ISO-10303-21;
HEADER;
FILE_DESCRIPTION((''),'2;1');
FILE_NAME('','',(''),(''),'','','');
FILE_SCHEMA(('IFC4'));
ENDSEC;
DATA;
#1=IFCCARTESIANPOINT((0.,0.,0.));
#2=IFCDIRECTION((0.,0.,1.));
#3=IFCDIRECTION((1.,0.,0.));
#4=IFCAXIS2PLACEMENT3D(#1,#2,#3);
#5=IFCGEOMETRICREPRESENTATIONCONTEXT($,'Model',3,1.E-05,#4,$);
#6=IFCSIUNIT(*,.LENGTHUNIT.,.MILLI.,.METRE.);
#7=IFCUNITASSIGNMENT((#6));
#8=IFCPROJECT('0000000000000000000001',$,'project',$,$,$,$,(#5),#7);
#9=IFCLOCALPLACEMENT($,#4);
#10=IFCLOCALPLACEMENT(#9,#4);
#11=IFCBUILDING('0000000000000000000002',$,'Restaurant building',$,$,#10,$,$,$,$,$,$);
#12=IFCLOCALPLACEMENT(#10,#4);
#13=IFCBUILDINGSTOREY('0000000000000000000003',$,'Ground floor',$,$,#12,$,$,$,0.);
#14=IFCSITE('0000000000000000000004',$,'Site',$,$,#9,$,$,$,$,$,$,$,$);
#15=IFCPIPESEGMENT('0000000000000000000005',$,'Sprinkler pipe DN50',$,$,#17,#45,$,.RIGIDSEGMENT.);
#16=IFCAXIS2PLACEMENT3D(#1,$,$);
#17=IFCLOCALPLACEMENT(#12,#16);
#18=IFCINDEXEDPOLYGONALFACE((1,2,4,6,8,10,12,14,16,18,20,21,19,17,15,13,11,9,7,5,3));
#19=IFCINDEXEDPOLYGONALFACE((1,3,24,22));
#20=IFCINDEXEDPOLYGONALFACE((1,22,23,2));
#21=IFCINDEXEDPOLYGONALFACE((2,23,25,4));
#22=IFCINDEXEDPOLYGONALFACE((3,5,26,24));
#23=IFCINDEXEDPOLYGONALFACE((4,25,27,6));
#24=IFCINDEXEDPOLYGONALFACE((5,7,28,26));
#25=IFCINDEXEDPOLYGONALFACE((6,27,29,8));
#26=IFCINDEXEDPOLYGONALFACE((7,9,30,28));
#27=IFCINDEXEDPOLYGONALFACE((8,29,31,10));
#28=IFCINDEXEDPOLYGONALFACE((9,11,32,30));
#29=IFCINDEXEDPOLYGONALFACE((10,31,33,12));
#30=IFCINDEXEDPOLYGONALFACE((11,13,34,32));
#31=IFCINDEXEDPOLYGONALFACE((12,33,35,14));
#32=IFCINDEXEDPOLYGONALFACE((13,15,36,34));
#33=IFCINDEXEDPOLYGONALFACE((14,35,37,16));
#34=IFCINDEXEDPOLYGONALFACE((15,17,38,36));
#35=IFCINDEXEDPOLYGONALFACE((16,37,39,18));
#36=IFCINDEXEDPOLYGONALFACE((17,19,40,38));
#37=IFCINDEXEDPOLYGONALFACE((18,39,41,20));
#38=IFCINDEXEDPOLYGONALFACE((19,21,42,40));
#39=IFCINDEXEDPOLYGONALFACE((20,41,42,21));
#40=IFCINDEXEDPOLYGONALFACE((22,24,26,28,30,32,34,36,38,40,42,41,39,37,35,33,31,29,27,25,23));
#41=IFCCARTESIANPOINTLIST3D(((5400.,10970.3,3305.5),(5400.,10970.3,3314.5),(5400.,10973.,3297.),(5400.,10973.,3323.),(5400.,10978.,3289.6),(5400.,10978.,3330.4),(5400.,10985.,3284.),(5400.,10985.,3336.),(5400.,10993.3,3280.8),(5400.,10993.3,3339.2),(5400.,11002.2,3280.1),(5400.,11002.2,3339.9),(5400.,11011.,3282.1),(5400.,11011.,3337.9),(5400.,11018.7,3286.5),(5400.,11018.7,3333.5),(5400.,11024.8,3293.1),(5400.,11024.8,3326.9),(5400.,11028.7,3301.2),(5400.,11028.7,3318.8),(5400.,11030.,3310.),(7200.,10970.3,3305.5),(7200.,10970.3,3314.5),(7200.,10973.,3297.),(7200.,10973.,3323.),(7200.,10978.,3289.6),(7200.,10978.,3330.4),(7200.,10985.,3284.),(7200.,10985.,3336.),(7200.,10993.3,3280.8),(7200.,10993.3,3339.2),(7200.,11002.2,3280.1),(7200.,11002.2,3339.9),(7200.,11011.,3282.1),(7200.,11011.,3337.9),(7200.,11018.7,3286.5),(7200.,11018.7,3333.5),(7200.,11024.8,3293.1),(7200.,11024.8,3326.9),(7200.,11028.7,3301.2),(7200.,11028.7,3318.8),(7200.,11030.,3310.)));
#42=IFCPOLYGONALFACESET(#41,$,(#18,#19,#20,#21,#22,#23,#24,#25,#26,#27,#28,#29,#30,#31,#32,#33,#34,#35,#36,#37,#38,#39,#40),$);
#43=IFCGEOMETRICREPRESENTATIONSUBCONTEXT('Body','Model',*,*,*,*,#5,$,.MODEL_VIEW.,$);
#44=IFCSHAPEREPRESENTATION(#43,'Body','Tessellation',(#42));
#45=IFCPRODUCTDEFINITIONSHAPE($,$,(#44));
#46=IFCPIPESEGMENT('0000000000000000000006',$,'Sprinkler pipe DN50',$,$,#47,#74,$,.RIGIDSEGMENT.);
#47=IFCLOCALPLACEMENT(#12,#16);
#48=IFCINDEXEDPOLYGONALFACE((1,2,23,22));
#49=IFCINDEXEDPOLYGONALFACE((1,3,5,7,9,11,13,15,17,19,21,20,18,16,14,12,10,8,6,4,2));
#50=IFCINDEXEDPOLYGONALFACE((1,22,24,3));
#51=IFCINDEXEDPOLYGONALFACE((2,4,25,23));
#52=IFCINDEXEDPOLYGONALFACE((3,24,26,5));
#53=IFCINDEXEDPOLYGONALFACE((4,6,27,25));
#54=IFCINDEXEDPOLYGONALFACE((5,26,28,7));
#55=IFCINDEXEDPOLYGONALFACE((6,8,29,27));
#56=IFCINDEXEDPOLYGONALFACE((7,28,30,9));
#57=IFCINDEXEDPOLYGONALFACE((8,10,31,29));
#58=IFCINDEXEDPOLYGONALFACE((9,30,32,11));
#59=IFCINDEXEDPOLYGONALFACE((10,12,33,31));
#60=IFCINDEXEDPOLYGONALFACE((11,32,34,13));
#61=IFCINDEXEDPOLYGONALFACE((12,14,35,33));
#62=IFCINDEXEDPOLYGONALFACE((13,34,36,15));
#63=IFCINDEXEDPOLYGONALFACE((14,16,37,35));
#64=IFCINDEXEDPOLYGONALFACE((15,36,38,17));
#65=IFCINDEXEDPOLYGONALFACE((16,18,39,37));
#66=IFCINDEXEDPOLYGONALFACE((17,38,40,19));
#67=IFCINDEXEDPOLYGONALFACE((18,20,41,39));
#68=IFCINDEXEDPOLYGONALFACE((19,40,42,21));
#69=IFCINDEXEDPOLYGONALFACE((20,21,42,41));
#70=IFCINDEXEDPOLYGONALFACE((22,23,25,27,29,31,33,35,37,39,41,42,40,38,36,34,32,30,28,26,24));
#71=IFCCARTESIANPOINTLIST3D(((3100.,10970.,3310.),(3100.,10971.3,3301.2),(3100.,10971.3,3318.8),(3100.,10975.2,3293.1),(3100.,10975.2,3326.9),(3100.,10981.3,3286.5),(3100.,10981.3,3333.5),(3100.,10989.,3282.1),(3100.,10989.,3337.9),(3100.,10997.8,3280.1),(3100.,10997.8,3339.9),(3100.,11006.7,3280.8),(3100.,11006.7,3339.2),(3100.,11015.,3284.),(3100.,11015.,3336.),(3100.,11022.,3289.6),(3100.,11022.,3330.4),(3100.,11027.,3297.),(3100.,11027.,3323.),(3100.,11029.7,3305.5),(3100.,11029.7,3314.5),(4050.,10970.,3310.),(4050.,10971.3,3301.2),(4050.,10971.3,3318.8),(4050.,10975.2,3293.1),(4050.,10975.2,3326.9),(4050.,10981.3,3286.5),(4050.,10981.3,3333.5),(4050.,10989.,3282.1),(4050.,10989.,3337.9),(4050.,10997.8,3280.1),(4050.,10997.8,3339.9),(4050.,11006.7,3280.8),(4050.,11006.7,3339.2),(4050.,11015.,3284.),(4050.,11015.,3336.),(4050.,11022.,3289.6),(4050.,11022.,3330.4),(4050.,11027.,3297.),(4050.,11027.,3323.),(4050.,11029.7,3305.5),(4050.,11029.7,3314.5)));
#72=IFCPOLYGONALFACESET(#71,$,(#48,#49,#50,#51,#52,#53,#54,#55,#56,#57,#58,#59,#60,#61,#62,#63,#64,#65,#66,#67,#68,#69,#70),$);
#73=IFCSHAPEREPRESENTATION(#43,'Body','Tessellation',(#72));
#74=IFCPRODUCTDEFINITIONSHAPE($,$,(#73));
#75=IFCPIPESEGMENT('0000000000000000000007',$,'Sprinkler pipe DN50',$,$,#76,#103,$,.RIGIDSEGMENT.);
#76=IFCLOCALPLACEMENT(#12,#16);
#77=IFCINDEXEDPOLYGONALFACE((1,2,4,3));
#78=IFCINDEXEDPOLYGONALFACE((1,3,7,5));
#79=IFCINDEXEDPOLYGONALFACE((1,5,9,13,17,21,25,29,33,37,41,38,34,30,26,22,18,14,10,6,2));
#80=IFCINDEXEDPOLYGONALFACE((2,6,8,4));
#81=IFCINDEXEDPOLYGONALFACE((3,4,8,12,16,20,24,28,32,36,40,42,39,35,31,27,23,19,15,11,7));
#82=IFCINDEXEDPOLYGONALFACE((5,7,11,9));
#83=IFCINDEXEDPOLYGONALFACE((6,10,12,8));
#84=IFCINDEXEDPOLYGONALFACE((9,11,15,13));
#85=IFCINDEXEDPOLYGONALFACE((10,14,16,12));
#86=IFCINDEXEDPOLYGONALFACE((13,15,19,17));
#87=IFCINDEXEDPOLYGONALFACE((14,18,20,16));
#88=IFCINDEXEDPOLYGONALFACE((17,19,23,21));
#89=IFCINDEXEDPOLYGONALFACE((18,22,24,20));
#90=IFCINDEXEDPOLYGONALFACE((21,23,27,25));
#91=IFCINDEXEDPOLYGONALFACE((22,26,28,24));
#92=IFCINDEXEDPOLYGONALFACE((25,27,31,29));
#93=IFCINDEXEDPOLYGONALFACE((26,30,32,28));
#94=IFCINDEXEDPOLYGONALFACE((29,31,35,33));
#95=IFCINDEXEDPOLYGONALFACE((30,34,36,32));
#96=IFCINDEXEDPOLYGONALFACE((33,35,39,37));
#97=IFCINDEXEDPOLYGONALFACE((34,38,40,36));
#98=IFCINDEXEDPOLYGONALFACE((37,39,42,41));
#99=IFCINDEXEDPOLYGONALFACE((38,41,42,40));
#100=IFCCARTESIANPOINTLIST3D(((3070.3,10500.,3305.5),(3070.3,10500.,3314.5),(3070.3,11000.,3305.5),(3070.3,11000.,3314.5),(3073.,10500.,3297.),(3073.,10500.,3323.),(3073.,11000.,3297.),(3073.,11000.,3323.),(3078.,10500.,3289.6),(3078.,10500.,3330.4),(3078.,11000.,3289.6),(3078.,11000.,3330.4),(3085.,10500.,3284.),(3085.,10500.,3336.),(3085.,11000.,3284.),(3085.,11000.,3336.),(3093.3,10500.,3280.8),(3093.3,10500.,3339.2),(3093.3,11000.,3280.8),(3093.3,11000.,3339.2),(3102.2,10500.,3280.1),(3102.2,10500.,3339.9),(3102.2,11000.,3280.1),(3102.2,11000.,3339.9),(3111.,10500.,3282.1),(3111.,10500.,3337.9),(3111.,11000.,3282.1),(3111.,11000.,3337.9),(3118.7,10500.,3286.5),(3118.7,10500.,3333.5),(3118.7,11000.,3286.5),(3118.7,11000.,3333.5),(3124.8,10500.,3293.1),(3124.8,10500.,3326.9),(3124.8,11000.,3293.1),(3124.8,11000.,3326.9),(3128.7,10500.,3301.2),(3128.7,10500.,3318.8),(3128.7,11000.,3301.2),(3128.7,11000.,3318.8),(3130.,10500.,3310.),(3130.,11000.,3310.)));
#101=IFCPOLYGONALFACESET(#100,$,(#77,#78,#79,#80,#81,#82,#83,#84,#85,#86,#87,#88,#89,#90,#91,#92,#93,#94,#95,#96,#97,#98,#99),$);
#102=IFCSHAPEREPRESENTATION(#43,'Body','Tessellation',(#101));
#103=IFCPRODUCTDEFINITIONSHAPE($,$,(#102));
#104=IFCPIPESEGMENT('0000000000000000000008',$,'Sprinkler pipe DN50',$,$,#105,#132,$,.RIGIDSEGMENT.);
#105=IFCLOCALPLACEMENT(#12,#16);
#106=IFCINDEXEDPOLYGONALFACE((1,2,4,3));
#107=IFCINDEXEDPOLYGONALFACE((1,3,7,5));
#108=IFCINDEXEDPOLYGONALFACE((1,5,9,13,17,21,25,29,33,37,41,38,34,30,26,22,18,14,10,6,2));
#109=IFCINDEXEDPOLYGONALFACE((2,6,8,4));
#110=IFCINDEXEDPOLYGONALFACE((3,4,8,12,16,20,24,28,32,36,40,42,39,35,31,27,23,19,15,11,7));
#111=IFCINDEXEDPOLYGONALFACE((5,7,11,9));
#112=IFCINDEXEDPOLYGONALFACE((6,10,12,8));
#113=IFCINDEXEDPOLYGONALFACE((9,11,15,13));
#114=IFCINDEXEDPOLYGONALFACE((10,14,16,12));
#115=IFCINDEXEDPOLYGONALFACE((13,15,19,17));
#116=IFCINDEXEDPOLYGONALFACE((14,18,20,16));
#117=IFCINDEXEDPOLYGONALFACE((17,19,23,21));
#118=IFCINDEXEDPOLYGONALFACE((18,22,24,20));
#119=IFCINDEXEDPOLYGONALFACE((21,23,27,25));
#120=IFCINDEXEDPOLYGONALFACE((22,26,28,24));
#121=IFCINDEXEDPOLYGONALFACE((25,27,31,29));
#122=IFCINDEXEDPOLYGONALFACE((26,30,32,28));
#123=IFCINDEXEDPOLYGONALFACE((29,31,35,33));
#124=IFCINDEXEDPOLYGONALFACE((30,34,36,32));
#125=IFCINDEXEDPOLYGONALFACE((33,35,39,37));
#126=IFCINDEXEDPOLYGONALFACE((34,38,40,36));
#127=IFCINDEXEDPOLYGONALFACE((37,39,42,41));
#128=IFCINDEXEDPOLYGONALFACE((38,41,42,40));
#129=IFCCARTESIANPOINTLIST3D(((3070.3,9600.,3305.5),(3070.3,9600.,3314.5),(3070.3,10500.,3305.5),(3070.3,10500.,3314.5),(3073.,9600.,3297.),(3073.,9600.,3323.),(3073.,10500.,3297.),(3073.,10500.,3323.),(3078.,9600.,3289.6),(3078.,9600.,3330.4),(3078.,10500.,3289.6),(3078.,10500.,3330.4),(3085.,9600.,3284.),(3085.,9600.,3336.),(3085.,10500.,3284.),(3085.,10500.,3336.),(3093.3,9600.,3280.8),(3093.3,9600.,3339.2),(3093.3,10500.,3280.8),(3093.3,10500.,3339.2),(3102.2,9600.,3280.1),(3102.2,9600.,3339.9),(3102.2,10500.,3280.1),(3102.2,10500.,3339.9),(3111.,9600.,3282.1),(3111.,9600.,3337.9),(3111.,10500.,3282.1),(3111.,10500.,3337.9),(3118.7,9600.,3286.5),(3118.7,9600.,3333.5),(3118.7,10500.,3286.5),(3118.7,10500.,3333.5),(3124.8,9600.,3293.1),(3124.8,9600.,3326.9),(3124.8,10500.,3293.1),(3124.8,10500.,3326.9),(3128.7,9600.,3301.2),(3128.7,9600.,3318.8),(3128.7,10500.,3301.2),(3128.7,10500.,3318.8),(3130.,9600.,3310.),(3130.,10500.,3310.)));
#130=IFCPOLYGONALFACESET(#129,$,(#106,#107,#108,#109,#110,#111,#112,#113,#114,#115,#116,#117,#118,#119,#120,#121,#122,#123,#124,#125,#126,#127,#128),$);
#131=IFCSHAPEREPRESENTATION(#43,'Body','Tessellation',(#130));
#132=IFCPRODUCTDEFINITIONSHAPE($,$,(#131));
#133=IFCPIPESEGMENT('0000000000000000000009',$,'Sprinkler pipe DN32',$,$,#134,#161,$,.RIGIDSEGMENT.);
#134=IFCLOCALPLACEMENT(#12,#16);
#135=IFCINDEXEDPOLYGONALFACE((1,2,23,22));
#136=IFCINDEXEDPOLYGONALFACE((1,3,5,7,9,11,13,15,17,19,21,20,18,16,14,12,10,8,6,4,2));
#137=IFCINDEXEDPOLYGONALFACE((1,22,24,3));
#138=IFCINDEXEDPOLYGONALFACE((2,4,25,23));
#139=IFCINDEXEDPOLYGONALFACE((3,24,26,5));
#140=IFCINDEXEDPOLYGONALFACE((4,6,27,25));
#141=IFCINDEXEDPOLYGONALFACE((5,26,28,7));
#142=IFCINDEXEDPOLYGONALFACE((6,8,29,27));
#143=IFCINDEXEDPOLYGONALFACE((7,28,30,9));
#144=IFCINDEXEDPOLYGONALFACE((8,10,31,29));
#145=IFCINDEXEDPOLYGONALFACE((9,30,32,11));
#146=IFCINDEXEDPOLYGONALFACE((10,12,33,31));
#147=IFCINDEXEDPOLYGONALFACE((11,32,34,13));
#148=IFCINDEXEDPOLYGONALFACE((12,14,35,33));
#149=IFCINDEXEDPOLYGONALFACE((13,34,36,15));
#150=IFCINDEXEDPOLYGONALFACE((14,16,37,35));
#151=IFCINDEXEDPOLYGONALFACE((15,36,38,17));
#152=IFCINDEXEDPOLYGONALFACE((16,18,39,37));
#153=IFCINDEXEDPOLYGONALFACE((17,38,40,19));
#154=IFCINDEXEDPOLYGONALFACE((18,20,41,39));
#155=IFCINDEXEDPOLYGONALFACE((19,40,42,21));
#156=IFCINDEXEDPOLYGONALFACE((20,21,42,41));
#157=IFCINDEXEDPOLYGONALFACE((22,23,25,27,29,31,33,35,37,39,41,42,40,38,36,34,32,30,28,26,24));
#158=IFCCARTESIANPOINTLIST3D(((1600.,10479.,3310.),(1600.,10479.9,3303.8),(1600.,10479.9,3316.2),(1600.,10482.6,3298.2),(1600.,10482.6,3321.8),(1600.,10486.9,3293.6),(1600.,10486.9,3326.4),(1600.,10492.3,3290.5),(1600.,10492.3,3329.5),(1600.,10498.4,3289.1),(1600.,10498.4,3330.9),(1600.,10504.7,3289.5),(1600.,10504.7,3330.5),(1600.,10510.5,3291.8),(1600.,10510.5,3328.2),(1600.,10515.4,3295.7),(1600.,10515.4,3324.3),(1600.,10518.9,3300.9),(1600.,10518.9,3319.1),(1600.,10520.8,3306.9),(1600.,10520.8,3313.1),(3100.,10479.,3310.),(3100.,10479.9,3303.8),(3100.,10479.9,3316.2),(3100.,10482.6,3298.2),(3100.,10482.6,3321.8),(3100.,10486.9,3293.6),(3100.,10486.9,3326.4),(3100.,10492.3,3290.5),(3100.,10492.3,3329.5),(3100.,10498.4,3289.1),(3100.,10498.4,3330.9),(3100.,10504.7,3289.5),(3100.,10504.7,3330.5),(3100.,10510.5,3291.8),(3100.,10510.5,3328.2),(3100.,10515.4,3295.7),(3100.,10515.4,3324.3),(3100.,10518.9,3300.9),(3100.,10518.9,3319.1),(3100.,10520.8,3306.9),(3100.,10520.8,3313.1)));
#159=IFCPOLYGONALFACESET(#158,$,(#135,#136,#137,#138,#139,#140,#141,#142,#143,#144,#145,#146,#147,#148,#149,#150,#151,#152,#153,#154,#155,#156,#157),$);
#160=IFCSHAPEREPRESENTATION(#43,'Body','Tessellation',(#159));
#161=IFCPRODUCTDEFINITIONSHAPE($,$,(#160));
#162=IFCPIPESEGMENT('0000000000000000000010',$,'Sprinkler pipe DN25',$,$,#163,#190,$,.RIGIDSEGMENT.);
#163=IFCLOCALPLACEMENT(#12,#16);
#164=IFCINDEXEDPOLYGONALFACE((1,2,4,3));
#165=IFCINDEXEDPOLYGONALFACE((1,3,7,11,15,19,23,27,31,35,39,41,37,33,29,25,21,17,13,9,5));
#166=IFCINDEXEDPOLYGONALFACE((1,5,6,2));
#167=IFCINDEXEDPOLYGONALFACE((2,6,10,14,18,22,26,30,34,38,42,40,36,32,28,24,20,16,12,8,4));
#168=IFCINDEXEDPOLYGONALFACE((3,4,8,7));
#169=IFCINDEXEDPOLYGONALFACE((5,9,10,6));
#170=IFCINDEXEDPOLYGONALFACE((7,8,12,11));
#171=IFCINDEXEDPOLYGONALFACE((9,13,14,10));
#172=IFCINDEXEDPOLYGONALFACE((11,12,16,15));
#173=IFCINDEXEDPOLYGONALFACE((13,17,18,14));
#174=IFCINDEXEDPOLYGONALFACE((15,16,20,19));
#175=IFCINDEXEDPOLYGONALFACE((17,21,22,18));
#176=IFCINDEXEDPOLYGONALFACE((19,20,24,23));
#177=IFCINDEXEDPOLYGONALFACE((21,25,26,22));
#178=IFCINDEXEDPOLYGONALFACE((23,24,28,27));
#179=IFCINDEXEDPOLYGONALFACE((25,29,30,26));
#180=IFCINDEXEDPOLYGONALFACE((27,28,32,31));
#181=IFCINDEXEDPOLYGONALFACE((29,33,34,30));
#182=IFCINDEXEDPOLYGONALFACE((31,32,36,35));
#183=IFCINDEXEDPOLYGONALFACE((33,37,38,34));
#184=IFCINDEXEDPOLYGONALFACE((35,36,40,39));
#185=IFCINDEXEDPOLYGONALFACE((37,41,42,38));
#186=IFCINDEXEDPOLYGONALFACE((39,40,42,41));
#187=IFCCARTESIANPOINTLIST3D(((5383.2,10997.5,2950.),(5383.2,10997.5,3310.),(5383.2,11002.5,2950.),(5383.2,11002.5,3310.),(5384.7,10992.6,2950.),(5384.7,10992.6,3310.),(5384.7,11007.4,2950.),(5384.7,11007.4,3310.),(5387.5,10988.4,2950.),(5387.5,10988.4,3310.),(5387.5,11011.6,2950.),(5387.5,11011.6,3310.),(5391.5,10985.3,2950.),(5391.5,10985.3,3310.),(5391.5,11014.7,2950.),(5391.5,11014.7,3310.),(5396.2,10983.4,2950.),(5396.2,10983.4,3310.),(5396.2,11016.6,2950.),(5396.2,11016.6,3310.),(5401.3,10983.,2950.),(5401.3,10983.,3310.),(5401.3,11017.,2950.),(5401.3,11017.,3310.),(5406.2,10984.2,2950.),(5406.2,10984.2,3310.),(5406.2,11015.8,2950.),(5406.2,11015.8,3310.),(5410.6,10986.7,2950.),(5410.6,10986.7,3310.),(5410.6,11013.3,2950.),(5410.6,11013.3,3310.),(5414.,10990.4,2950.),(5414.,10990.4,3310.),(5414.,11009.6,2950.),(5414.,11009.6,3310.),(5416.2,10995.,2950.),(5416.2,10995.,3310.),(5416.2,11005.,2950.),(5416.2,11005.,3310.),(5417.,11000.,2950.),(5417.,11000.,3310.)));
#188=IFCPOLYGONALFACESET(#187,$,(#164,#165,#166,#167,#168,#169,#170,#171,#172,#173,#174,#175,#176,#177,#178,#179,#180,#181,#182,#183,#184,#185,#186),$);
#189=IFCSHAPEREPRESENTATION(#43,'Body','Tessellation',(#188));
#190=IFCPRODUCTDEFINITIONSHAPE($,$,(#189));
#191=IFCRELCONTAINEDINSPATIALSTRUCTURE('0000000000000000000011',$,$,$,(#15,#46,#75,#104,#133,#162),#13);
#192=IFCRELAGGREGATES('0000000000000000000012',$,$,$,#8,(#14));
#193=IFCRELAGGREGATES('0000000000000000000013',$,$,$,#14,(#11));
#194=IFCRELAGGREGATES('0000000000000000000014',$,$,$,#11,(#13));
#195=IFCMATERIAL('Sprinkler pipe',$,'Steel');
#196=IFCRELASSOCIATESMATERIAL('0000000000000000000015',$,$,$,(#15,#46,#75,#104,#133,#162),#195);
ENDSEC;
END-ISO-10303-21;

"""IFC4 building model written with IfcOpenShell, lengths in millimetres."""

from ifc_helpers import new_model, si_unit, frame, origin_with_axes, origin_2d, place, context, subcontext, project, spatial, circle, extrude, material, element, save


model = new_model("IFC4")

# Units and contexts
model_context = context("Model", 3, precision=1e-05, world=origin_with_axes())
body_context = subcontext(model_context, "Body", "Model", "MODEL_VIEW")
ifc_project = project(units=[si_unit("LENGTHUNIT", "METRE", prefix="MILLI")], contexts=[model_context])

# Site, building, storey
site_placement = place(None, origin_with_axes())
site = spatial("IfcSite", under=ifc_project, at=site_placement, Name="Site")
building_placement = place(site_placement, origin_with_axes())
building = spatial("IfcBuilding", under=site, at=building_placement, Name="Restaurant building")
storey_placement = place(building_placement, origin_with_axes())
storey = spatial("IfcBuildingStorey", under=building, at=storey_placement, Name="Ground floor", Elevation=0.0)

# Pipe segments
ifc_material_1 = material(Name="Sprinkler pipe", Category="Steel")
pipe_segment_1_placement = place(storey_placement, frame((5400.0, 11000.0, 3310.0)))
element("IfcPipeSegment", 1, at=pipe_segment_1_placement, inside=storey, material=ifc_material_1, Name="Sprinkler pipe DN50", PredefinedType="RIGIDSEGMENT", context=body_context, shape_type="SweptSolid", body=[
    extrude(circle(Radius=30.0, at=origin_2d()), frame((0.0, 0.0, 0.0), z_axis=(1.0, 0.0, 0.0), x_axis=(0.0, 1.0, 0.0)), (0.0, 0.0, 1.0), 1800.0),
])
pipe_segment_2_placement = place(storey_placement, frame((4050.0, 11000.0, 3310.0)))
element("IfcPipeSegment", 2, at=pipe_segment_2_placement, inside=storey, material=ifc_material_1, Name="Sprinkler pipe DN50", PredefinedType="RIGIDSEGMENT", context=body_context, shape_type="SweptSolid", body=[
    extrude(circle(Radius=30.0, at=origin_2d()), frame((0.0, 0.0, 0.0), z_axis=(-1.0, 0.0, 0.0), x_axis=(0.0, -1.0, 0.0)), (0.0, 0.0, 1.0), 950.0),
])
pipe_segment_3_placement = place(storey_placement, frame((3100.0, 11000.0, 3310.0)))
element("IfcPipeSegment", 3, at=pipe_segment_3_placement, inside=storey, material=ifc_material_1, Name="Sprinkler pipe DN50", PredefinedType="RIGIDSEGMENT", context=body_context, shape_type="SweptSolid", body=[
    extrude(circle(Radius=30.0, at=origin_2d()), frame((0.0, 0.0, 0.0), z_axis=(0.0, -1.0, 0.0), x_axis=(1.0, 0.0, 0.0)), (0.0, 0.0, 1.0), 500.0),
])
pipe_segment_4_placement = place(storey_placement, frame((3100.0, 10500.0, 3310.0)))
element("IfcPipeSegment", 4, at=pipe_segment_4_placement, inside=storey, material=ifc_material_1, Name="Sprinkler pipe DN50", PredefinedType="RIGIDSEGMENT", context=body_context, shape_type="SweptSolid", body=[
    extrude(circle(Radius=30.0, at=origin_2d()), frame((0.0, 0.0, 0.0), z_axis=(0.0, -1.0, 0.0), x_axis=(1.0, 0.0, 0.0)), (0.0, 0.0, 1.0), 900.0),
])
pipe_segment_5_placement = place(storey_placement, frame((3100.0, 10500.0, 3310.0)))
element("IfcPipeSegment", 5, at=pipe_segment_5_placement, inside=storey, material=ifc_material_1, Name="Sprinkler pipe DN32", PredefinedType="RIGIDSEGMENT", context=body_context, shape_type="SweptSolid", body=[
    extrude(circle(Radius=21.0, at=origin_2d()), frame((0.0, 0.0, 0.0), z_axis=(-1.0, 0.0, 0.0), x_axis=(0.0, -1.0, 0.0)), (0.0, 0.0, 1.0), 1500.0),
])
pipe_segment_6_placement = place(storey_placement, frame((5400.0, 11000.0, 3310.0)))
element("IfcPipeSegment", 6, at=pipe_segment_6_placement, inside=storey, material=ifc_material_1, Name="Sprinkler pipe DN25", PredefinedType="RIGIDSEGMENT", context=body_context, shape_type="SweptSolid", body=[
    extrude(circle(Radius=17.0, at=origin_2d()), frame((0.0, 0.0, 0.0), z_axis=(0.0, 0.0, -1.0), x_axis=(1.0, 0.0, 0.0)), (0.0, 0.0, 1.0), 360.0),
])

save(model, "model.ifc")
